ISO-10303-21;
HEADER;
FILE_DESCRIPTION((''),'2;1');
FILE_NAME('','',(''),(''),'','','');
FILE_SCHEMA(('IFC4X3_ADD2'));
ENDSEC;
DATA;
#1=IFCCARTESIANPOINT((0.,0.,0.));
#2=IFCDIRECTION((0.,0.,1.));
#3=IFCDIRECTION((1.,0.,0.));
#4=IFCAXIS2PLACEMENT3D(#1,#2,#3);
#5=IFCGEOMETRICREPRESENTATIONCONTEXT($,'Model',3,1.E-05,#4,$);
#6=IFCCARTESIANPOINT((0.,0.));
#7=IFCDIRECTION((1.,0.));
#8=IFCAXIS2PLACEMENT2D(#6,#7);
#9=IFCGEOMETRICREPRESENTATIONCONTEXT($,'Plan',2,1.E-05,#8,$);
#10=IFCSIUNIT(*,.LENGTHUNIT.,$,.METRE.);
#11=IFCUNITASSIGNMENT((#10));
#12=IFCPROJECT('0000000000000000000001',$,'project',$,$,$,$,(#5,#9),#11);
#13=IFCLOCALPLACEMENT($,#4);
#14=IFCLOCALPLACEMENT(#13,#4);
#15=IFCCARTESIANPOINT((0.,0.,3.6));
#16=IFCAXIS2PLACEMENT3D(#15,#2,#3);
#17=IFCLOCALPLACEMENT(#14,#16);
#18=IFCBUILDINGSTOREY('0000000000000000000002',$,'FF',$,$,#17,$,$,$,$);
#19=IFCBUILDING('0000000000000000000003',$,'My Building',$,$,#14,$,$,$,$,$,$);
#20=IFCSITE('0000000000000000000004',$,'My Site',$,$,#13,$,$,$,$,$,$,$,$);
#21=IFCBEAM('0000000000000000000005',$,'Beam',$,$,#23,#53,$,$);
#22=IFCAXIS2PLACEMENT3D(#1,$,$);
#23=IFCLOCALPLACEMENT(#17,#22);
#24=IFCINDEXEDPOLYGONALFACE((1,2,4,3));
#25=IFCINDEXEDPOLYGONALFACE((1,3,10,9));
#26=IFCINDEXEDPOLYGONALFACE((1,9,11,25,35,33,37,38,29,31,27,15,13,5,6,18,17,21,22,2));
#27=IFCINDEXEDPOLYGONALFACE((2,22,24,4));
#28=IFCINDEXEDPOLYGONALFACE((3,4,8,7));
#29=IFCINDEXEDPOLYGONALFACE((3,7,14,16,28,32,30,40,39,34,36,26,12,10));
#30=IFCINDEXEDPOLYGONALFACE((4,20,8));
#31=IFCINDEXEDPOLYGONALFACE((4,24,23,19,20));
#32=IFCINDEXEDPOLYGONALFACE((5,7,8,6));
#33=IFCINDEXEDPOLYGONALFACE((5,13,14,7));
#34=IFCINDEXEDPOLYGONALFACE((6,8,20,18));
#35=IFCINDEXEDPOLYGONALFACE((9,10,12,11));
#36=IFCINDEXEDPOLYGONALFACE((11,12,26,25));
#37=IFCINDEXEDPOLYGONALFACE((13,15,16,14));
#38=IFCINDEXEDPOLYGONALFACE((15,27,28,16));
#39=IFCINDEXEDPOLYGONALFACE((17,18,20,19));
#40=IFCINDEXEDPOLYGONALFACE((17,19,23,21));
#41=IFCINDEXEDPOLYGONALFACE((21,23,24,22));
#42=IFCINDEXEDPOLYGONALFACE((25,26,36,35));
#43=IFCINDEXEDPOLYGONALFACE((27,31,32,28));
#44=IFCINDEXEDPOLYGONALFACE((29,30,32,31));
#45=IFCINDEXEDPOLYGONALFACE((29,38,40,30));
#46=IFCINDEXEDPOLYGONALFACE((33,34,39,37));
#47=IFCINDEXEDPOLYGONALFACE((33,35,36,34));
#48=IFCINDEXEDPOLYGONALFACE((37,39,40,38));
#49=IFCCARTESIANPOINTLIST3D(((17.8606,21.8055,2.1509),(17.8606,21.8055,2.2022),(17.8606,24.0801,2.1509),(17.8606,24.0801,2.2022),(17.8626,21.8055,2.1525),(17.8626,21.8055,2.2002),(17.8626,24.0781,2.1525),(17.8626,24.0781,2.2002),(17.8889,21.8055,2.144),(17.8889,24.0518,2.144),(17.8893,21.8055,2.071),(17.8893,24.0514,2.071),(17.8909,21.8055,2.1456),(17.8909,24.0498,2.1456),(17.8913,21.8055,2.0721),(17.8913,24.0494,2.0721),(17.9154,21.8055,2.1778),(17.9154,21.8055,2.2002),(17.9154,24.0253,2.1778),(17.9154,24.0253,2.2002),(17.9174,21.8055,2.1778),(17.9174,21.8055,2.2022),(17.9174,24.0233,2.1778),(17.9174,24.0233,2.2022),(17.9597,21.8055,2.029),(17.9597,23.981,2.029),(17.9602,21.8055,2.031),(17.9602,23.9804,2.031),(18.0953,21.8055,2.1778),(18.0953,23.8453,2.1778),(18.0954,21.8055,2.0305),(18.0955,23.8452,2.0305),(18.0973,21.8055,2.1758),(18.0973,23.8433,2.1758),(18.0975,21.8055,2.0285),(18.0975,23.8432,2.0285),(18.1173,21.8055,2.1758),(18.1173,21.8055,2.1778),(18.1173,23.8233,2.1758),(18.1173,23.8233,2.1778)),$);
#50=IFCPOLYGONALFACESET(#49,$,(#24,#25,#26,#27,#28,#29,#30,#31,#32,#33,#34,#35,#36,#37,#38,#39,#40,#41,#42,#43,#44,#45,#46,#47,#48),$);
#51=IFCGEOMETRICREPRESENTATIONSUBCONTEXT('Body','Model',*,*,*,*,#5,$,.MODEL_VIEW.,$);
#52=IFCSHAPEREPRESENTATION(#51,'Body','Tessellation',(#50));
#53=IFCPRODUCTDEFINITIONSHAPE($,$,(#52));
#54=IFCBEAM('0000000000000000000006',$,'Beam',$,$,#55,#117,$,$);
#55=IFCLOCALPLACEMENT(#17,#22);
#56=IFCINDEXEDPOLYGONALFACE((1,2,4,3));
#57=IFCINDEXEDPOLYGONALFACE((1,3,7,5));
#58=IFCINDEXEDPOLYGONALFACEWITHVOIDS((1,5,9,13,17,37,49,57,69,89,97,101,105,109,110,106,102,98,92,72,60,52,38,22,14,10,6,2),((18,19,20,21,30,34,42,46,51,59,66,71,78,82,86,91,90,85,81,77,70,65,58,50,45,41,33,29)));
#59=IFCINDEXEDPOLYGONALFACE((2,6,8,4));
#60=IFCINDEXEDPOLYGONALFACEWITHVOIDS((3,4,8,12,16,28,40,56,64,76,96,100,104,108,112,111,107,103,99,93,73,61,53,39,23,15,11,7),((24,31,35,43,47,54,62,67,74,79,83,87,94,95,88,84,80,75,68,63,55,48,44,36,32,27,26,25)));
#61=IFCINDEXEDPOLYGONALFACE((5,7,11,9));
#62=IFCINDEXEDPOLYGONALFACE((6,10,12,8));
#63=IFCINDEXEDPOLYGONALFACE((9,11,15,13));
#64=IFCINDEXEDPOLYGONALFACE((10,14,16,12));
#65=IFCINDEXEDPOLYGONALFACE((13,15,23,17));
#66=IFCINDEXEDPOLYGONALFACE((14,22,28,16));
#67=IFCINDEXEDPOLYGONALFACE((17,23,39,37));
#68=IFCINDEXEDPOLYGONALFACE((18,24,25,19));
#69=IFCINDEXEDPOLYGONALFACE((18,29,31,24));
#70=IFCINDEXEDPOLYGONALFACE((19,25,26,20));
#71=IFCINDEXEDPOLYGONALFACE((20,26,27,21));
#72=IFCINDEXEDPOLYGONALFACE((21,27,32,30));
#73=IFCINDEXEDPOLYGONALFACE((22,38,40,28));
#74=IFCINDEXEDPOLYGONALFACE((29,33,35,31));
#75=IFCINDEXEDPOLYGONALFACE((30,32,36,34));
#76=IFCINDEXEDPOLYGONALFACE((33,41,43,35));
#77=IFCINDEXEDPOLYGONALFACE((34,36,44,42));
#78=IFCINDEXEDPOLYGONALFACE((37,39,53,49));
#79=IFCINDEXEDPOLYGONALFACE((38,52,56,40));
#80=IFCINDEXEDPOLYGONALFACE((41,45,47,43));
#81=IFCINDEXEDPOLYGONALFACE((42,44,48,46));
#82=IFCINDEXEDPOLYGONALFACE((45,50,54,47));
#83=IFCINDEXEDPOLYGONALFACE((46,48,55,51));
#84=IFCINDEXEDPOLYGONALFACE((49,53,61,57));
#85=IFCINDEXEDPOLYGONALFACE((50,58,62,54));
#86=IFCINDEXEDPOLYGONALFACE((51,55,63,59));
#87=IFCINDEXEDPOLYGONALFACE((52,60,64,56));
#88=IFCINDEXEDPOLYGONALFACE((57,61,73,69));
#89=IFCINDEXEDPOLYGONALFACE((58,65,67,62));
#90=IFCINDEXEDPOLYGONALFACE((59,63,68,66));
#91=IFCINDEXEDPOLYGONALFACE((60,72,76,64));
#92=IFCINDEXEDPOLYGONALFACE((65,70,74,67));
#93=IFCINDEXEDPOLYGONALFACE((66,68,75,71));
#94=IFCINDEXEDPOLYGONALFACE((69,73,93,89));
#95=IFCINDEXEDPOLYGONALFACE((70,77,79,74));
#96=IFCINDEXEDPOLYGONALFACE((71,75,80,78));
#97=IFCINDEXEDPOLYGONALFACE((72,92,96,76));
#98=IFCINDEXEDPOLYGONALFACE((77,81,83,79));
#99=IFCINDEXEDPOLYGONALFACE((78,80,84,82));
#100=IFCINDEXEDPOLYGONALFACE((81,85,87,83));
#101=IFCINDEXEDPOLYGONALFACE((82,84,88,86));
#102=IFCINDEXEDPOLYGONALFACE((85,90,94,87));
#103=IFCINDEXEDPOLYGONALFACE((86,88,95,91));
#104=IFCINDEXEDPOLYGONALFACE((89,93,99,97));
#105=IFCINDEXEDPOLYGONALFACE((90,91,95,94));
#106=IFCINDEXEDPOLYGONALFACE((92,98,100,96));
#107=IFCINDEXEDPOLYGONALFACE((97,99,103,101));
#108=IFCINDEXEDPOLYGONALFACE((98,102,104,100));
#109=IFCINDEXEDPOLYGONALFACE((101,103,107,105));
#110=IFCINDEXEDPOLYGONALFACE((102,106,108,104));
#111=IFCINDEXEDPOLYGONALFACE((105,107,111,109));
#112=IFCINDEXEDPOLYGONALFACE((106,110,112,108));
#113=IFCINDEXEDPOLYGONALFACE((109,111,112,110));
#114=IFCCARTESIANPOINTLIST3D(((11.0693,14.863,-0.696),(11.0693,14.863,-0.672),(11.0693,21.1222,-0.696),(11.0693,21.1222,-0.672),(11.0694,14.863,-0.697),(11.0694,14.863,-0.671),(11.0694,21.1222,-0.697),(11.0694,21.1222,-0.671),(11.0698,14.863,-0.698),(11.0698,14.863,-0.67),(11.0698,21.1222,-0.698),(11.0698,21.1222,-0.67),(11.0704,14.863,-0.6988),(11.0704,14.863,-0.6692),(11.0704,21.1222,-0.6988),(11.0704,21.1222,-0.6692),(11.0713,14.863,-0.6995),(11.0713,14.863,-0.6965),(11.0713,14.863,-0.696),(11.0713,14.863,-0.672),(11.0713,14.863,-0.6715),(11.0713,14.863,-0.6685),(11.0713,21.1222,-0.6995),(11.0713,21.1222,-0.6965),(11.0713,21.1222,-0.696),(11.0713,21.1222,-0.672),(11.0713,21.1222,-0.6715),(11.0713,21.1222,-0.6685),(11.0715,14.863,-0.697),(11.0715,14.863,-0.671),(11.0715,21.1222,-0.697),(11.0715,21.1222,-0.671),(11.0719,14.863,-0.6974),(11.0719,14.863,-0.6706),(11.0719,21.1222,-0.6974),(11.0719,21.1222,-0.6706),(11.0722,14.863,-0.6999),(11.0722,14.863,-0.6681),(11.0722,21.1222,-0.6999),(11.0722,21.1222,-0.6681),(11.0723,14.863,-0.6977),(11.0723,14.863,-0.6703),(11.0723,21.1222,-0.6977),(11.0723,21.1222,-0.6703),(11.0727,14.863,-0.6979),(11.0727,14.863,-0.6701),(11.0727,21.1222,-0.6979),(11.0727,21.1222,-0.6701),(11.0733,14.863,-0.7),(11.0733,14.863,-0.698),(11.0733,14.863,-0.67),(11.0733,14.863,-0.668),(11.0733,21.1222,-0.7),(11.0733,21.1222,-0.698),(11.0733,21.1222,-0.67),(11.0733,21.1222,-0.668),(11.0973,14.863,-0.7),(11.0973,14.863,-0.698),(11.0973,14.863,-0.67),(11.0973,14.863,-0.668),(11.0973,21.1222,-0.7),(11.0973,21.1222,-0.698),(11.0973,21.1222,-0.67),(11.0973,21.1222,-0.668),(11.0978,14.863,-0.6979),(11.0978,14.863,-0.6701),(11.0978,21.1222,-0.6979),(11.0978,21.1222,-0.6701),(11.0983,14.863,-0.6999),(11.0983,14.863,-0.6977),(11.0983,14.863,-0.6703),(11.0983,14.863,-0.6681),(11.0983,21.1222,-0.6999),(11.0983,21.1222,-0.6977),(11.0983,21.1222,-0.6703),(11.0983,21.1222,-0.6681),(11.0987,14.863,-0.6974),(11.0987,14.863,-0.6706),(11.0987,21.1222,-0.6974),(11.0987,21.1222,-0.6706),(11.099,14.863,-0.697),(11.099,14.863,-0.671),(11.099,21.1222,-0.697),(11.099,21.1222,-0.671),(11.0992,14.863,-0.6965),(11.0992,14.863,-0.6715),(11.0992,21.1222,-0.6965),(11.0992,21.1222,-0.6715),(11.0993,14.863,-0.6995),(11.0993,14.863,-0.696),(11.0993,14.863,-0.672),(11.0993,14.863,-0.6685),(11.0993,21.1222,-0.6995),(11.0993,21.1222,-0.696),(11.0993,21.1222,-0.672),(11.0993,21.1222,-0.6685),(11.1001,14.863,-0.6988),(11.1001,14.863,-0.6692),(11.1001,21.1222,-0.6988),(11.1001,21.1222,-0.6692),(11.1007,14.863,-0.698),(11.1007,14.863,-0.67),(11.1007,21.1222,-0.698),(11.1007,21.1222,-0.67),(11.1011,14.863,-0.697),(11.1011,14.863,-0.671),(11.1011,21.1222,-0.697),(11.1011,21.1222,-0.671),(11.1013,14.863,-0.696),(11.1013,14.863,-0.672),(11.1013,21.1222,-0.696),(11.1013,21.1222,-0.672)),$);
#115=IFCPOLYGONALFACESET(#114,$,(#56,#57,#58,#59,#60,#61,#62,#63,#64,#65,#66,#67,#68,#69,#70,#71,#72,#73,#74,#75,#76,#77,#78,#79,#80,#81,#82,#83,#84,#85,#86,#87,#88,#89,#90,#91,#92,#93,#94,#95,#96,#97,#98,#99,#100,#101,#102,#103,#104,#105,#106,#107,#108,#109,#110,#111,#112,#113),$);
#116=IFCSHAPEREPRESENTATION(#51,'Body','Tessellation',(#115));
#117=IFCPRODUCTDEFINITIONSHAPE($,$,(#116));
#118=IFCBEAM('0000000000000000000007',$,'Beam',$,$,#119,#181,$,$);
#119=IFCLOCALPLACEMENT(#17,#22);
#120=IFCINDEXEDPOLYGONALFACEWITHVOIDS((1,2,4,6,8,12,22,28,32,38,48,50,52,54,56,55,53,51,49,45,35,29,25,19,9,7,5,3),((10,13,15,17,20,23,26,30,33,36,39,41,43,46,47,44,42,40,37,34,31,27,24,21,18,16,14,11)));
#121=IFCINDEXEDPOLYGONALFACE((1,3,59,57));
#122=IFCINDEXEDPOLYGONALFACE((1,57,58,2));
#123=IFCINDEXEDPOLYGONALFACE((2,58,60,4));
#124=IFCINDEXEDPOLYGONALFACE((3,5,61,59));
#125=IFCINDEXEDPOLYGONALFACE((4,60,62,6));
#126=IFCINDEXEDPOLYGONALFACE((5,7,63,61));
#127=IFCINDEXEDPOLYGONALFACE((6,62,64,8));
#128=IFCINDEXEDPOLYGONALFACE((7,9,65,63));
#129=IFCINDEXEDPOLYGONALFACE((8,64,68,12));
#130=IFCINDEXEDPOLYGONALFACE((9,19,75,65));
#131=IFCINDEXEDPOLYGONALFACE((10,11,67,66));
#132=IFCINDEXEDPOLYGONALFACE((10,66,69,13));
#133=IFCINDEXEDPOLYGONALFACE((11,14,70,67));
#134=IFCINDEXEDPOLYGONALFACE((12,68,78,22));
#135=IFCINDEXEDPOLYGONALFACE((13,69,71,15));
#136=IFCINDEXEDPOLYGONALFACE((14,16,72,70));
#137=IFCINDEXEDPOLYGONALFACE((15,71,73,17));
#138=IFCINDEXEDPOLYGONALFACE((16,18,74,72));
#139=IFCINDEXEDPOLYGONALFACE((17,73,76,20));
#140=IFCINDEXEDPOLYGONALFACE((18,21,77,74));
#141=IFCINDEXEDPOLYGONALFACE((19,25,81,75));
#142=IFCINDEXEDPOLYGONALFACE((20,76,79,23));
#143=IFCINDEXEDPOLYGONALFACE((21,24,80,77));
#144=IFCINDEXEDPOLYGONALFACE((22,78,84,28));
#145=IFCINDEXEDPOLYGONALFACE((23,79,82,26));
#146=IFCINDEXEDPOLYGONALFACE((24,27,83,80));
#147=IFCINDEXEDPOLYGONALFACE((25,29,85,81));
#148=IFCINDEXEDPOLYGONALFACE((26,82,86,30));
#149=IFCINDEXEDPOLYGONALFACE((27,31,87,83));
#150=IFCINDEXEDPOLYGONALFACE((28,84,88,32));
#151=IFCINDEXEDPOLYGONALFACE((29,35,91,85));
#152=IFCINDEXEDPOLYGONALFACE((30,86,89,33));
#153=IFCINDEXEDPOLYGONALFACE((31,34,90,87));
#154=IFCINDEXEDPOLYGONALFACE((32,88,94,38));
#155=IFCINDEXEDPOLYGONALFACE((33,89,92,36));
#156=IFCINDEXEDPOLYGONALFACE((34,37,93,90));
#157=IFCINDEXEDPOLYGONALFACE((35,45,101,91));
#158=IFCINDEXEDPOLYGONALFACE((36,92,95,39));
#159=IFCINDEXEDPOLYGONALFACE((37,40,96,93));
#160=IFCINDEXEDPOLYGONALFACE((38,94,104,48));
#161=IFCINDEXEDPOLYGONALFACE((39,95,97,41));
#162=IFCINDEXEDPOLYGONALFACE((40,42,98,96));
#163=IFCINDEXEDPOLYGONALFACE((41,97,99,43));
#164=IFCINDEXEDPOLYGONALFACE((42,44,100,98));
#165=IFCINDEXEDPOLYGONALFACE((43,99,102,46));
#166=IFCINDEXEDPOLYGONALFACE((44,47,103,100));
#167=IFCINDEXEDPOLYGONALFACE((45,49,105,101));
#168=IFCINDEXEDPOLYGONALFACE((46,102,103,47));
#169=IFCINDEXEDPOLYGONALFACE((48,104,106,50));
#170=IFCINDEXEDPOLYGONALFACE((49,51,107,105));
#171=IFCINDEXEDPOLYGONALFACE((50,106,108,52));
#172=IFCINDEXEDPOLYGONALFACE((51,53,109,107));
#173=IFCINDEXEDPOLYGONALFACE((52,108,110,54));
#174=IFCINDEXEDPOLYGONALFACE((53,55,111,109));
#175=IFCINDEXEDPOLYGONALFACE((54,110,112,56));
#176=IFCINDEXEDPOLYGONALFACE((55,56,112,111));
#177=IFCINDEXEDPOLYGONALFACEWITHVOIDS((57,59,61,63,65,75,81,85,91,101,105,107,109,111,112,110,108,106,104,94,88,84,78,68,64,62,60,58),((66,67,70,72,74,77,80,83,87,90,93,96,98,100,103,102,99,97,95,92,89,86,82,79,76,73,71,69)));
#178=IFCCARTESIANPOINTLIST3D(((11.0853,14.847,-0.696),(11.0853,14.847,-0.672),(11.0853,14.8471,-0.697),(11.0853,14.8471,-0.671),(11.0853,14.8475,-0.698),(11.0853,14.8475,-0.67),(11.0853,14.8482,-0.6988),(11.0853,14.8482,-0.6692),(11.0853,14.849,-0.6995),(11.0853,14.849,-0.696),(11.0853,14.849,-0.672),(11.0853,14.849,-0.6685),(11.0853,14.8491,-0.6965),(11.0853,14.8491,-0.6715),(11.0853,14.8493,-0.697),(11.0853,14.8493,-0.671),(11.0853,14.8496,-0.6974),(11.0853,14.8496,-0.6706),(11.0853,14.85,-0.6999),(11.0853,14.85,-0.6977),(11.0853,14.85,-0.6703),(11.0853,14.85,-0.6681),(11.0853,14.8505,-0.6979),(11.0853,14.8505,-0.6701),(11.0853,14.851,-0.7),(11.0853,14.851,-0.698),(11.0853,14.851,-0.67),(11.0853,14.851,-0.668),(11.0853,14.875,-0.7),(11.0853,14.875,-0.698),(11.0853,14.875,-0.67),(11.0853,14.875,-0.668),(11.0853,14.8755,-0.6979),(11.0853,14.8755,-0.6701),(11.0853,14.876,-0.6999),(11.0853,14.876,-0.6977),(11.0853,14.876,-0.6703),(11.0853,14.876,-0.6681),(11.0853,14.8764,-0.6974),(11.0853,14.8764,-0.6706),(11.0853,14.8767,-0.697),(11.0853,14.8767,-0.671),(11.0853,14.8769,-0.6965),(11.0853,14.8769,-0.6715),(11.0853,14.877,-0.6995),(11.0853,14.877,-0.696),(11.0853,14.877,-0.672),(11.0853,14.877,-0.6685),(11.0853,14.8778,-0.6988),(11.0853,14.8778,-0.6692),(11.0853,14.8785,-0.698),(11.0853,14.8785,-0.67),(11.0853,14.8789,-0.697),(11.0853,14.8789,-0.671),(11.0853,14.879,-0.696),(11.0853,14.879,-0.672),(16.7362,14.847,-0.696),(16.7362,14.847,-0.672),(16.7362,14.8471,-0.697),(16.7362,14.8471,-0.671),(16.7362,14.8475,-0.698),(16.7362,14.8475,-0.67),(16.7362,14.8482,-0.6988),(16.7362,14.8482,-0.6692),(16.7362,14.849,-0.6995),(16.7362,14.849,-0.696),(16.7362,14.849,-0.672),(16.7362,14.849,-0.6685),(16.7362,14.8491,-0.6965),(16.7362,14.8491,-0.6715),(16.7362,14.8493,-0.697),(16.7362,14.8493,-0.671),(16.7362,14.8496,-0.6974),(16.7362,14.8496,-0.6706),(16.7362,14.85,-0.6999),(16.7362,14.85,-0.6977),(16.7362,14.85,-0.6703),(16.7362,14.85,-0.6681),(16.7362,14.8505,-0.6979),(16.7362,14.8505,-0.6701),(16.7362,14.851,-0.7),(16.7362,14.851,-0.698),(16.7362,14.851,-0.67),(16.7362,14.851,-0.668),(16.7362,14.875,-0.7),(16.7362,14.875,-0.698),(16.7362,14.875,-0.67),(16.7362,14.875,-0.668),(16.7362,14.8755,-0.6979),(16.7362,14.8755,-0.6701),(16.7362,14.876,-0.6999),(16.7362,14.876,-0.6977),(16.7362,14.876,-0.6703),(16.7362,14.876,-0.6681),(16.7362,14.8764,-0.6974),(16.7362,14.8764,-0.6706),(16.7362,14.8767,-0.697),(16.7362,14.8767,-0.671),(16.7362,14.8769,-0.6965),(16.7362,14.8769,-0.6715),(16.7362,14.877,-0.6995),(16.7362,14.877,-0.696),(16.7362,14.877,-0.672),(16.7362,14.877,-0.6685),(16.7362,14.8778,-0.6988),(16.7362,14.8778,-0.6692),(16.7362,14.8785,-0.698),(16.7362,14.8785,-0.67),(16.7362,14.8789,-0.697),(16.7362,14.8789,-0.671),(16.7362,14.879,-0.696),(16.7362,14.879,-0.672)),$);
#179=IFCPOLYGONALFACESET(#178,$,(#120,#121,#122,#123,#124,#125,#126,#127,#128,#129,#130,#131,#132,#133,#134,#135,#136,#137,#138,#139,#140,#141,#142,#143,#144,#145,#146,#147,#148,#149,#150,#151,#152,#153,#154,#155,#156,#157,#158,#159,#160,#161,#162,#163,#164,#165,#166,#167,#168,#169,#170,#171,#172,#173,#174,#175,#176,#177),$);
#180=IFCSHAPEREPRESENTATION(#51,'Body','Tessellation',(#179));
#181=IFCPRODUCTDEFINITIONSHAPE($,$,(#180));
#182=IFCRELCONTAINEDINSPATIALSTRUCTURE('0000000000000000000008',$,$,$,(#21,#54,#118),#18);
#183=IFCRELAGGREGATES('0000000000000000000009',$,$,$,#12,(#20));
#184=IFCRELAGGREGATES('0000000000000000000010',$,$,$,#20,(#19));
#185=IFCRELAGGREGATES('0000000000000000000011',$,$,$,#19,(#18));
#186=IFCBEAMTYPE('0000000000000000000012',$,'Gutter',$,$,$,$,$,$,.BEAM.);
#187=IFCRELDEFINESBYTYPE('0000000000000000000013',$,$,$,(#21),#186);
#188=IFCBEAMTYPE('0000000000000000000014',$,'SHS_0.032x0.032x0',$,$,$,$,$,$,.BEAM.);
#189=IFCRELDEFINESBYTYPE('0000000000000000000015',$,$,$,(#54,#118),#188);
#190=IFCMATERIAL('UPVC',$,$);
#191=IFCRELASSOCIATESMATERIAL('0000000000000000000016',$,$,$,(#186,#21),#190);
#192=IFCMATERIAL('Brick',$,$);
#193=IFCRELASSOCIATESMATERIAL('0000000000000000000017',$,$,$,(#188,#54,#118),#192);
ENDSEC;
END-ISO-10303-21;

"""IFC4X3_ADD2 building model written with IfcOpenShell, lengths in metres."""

from ifc_helpers import new_model, si_unit, frame, origin_with_axes, origin_2d_with_axis, place, context, subcontext, project, spatial, indexed_curve, hollow_rectangle, outline, extrude, clip, halfspace, material, material_profile, profile_set, profile_usage, type_object, element, save


model = new_model("IFC4X3_ADD2")

# Units and contexts
model_context = context("Model", 3, precision=1e-05, world=origin_with_axes())
plan_context = context("Plan", 2, precision=1e-05, world=origin_2d_with_axis())
body_context_1 = subcontext(model_context, "Body", "Model", "MODEL_VIEW")
ifc_project = project(units=[si_unit("LENGTHUNIT", "METRE")], contexts=[model_context, plan_context])

# Site, building, storey
site_placement = place(None, origin_with_axes())
site = spatial("IfcSite", under=ifc_project, at=site_placement, Name="My Site")
building_placement = place(site_placement, origin_with_axes())
building = spatial("IfcBuilding", under=site, at=building_placement, Name="My Building")
storey_placement = place(building_placement, frame((0.0, 0.0, 3.6), z_axis=(0.0, 0.0, 1.0), x_axis=(1.0, 0.0, 0.0)))
storey = spatial("IfcBuildingStorey", under=building, at=storey_placement, Name="FF")

# Beams
ifc_material_1 = material(Name="UPVC")
ifc_material_profile_1 = material_profile(ifc_material_1, outline(indexed_curve([(0.0548, 0.1717), (0.002, 0.1717), (0.002, 0.124), (0.0303, 0.1171), (0.0307, 0.0436), (0.0996, 0.0025), (0.2349, 0.002), (0.2347, 0.1494), (0.2567, 0.1494), (0.2567, 0.1474), (0.2367, 0.1474), (0.2369, 0.0), (0.0991, 0.0005), (0.0287, 0.0425), (0.0283, 0.1155), (0.0, 0.1224), (0.0, 0.1737), (0.0568, 0.1737), (0.0568, 0.1494), (0.0548, 0.1494), (0.0548, 0.1717)])))
ifc_profile_set_1 = profile_set([ifc_material_profile_1])
ifc_profile_usage_1 = profile_usage(ifc_profile_set_1)
beam_type_1 = type_object("IfcBeamType", Name="Gutter", PredefinedType="BEAM", material=ifc_profile_set_1)
beam_1_placement = place(storey_placement, frame((17.8606, 24.0801, 2.0285), z_axis=(0.0, -1.0, 0.0), x_axis=(1.0, 0.0, 0.0)))
element("IfcBeam", 1, at=beam_1_placement, inside=storey, type_object=beam_type_1, material=ifc_profile_usage_1, Name="Beam", context=body_context_1, shape_type="Clipping", body=[
    clip(extrude(outline(indexed_curve([(0.0548, 0.1717), (0.002, 0.1717), (0.002, 0.124), (0.0303, 0.1171), (0.0307, 0.0436), (0.0996, 0.0025), (0.2349, 0.002), (0.2347, 0.1494), (0.2567, 0.1494), (0.2567, 0.1474), (0.2367, 0.1474), (0.2369, 0.0), (0.0991, 0.0005), (0.0287, 0.0425), (0.0283, 0.1155), (0.0, 0.1224), (0.0, 0.1737), (0.0568, 0.1737), (0.0568, 0.1494), (0.0548, 0.1494), (0.0548, 0.1717)])), origin_with_axes(), (0.0, 0.0, 1.0), 2.2745), halfspace(frame((0.0, -5.6285, 0.0), z_axis=(0.707106, 0.0, -0.707107), x_axis=(0.0, -1.0, 0.0)), False)),
])
ifc_material_2 = material(Name="Brick")
ifc_material_profile_2 = material_profile(ifc_material_2, hollow_rectangle(XDim=0.032, YDim=0.032, WallThickness=0.002, InnerFilletRadius=0.002, OuterFilletRadius=0.004))
ifc_profile_set_2 = profile_set([ifc_material_profile_2])
ifc_profile_usage_2 = profile_usage(ifc_profile_set_2, cardinal=5)
ifc_material_profile_3 = material_profile(ifc_material_2, hollow_rectangle(XDim=0.032, YDim=0.032, WallThickness=0.002, InnerFilletRadius=0.002, OuterFilletRadius=0.004))
ifc_profile_set_3 = profile_set([ifc_material_profile_3])
beam_type_2 = type_object("IfcBeamType", Name="SHS_0.032x0.032x0", PredefinedType="BEAM", material=ifc_profile_set_3)
beam_2_placement = place(storey_placement, frame((11.0853, 14.863, -0.684), z_axis=(0.0, 1.0, 0.0), x_axis=(-1.0, 0.0, 0.0)))
element("IfcBeam", 2, at=beam_2_placement, inside=storey, type_object=beam_type_2, material=ifc_profile_usage_2, Name="Beam", context=body_context_1, shape_type="SweptSolid", body=[
    extrude(hollow_rectangle(XDim=0.032, YDim=0.032, WallThickness=0.002, InnerFilletRadius=0.002, OuterFilletRadius=0.004), origin_with_axes(), (0.0, 0.0, 1.0), 6.2592),
])
ifc_material_profile_4 = material_profile(ifc_material_2, hollow_rectangle(XDim=0.032, YDim=0.032, WallThickness=0.002, InnerFilletRadius=0.002, OuterFilletRadius=0.004))
ifc_profile_set_4 = profile_set([ifc_material_profile_4])
ifc_profile_usage_3 = profile_usage(ifc_profile_set_4, cardinal=5)
beam_3_placement = place(storey_placement, frame((11.0853, 14.863, -0.684), z_axis=(1.0, 0.0, 0.0), x_axis=(0.0, 1.0, 0.0)))
element("IfcBeam", 3, at=beam_3_placement, inside=storey, type_object=beam_type_2, material=ifc_profile_usage_3, Name="Beam", context=body_context_1, shape_type="SweptSolid", body=[
    extrude(hollow_rectangle(XDim=0.032, YDim=0.032, WallThickness=0.002, InnerFilletRadius=0.002, OuterFilletRadius=0.004), origin_with_axes(), (0.0, 0.0, 1.0), 5.651),
])

save(model, "model.ifc")
